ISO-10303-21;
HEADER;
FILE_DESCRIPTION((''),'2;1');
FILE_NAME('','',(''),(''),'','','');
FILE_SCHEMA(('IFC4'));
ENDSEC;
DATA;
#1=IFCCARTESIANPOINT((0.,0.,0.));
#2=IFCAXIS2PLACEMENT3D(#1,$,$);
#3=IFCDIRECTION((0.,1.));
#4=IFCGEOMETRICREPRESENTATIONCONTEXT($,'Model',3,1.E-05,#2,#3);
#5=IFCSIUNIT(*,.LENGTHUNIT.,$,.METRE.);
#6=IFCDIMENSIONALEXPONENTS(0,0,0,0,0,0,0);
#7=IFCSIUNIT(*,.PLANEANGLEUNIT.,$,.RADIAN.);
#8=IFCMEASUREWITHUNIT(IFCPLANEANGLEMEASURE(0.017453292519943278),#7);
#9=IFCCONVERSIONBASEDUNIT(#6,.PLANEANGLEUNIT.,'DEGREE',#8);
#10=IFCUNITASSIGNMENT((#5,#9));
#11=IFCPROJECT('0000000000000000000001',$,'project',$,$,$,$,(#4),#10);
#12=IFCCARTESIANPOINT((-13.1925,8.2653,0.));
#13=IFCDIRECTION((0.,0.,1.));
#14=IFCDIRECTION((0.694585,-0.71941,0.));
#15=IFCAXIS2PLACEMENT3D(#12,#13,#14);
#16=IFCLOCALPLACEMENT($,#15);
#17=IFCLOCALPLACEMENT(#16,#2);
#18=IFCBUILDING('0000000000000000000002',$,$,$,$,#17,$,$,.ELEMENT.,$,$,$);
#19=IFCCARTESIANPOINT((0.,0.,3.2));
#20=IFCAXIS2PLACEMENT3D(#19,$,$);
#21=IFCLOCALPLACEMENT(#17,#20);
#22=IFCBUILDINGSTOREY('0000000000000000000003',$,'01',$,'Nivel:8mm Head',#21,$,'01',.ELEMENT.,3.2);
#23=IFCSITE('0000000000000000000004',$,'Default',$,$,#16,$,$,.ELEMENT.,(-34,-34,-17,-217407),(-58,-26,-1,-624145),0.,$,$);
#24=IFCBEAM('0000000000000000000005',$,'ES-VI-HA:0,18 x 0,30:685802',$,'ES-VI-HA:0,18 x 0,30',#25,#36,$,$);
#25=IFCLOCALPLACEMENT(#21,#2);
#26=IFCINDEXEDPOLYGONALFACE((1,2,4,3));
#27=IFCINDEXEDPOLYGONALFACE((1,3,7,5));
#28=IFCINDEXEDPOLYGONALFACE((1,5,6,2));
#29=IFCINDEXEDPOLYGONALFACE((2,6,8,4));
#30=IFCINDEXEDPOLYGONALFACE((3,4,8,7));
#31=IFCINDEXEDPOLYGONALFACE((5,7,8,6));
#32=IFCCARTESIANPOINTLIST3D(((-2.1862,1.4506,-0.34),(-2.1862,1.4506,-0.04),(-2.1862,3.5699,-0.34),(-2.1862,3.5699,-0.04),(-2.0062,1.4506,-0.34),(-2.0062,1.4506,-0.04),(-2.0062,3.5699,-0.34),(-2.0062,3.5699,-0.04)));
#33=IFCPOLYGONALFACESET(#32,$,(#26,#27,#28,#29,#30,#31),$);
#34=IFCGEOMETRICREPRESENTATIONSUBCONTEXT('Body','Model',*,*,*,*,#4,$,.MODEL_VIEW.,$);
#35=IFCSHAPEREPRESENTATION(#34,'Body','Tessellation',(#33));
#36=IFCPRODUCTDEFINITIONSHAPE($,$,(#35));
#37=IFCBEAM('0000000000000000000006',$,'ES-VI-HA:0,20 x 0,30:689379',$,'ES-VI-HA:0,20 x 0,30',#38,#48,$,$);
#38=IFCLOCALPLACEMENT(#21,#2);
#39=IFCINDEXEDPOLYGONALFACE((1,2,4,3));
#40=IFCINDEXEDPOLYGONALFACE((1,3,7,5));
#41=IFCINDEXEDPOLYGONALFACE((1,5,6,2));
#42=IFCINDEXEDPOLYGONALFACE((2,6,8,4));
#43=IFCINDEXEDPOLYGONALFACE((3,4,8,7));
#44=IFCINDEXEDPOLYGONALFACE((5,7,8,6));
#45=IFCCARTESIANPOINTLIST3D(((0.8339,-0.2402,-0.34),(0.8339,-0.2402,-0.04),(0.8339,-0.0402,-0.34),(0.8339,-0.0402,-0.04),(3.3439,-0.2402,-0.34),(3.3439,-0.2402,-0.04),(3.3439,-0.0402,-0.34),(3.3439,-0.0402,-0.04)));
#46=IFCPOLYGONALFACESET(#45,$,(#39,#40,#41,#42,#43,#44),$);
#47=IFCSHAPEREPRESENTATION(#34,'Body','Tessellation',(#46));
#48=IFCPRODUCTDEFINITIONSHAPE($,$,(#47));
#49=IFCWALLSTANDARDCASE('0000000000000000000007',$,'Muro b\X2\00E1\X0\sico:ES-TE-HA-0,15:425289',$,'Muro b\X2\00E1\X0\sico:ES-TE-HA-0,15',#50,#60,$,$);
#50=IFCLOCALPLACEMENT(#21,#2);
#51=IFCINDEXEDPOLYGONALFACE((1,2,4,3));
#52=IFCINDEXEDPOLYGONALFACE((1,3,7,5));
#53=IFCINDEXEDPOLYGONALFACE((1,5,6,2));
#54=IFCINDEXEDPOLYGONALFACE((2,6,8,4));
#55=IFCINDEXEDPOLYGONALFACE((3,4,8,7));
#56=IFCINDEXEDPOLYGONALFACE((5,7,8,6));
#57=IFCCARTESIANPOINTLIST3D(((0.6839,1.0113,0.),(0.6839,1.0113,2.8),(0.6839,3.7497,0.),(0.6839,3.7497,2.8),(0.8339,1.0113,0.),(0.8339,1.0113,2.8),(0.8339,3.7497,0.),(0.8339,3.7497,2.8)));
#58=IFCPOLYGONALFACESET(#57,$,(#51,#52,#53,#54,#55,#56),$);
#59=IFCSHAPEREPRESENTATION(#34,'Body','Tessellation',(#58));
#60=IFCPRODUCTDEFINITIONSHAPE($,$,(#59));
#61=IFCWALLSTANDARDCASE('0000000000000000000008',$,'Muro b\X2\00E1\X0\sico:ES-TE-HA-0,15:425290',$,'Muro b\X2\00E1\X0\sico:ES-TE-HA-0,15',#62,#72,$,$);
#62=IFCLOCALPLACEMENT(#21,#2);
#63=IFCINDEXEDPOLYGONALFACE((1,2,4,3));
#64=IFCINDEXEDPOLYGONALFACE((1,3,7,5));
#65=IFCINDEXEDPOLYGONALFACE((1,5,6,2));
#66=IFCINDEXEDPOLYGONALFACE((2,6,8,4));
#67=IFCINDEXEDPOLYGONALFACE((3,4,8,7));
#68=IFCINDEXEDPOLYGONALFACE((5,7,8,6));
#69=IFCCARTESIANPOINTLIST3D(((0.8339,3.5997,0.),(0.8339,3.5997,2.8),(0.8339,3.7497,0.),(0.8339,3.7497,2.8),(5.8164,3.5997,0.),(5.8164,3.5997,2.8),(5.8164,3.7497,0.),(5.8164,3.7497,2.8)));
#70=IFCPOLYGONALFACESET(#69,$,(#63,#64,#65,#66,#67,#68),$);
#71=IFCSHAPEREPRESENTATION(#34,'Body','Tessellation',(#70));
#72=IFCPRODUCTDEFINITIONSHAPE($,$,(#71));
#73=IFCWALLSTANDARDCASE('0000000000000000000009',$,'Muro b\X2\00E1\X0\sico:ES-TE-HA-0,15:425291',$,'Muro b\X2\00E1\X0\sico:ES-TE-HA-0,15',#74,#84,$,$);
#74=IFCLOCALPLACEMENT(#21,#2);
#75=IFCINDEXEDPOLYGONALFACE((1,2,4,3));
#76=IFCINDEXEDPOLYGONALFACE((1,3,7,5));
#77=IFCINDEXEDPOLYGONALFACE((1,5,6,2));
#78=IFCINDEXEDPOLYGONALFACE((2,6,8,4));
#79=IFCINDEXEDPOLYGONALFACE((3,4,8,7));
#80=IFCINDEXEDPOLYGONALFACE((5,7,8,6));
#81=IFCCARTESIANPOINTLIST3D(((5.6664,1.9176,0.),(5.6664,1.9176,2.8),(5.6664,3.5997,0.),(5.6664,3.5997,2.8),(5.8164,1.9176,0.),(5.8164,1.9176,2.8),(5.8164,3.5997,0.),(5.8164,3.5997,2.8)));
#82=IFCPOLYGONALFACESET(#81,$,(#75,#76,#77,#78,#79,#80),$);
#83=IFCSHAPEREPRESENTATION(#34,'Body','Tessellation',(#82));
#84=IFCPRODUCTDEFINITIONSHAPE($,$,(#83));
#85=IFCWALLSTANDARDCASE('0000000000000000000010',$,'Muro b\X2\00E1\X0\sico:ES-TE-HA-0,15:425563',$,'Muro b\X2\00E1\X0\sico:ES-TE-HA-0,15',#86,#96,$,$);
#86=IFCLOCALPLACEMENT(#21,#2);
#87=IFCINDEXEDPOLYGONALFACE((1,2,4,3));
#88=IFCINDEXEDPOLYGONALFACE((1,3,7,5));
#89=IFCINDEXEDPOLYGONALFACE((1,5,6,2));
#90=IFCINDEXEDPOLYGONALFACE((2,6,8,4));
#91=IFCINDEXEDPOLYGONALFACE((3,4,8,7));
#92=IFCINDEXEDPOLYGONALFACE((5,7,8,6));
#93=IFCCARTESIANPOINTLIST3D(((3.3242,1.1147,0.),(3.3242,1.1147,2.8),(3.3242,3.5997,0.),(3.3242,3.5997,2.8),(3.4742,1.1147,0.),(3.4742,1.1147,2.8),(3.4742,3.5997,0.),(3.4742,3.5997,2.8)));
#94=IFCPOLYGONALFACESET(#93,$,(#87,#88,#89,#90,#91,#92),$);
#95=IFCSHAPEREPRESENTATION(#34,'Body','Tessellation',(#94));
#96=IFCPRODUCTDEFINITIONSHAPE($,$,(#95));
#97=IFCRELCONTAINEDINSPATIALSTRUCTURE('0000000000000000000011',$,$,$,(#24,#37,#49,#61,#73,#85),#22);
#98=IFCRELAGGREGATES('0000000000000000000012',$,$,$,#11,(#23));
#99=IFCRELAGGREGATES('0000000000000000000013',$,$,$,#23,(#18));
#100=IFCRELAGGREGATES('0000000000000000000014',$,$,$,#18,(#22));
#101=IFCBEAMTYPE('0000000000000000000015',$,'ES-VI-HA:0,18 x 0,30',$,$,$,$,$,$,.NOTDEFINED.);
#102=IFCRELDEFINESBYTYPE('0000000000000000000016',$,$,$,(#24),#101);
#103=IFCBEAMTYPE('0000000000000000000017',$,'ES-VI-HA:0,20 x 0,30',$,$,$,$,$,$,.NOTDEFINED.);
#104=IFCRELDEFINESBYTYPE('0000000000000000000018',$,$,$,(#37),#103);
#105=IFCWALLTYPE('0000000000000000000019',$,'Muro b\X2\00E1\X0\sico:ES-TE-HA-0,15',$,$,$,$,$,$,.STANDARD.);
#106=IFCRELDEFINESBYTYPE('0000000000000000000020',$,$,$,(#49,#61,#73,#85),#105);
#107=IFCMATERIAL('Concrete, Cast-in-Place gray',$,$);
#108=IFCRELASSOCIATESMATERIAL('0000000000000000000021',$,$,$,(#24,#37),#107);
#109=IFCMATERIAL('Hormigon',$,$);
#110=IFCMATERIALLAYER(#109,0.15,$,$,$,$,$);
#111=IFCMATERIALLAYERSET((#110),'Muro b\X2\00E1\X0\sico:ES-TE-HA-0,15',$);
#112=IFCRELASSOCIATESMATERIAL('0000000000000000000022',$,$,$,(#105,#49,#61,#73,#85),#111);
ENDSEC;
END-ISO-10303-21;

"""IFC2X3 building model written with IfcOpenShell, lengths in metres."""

from ifc_helpers import new_model, entity, si_unit, converted_unit, direction, frame, frame_2d, origin, place, context, subcontext, project, spatial, rectangle, extrude, material, layer, layer_set, layer_usage, type_object, element, save


model = new_model("IFC2X3")

# Units and contexts
model_context = context("Model", 3, precision=1e-05, world=origin(), true_north=direction((0.0, 1.0)))
body_context = subcontext(model_context, "Body", "Model", "MODEL_VIEW")
ifc_project = project(units=[si_unit("LENGTHUNIT", "METRE"), converted_unit("PLANEANGLEUNIT", "DEGREE", entity("IfcPlaneAngleMeasure", 0.017453292519943278), si_unit("PLANEANGLEUNIT", "RADIAN"), dimensions=[0, 0, 0, 0, 0, 0, 0])], contexts=[model_context])

# Site, building, storey
site_placement = place(None, frame((-13.1925, 8.2653, 0.0), z_axis=(0.0, 0.0, 1.0), x_axis=(0.694585, -0.71941, 0.0)))
site = spatial("IfcSite", under=ifc_project, at=site_placement, Name="Default", CompositionType="ELEMENT", RefLatitude=(-34, -34, -17, -217407), RefLongitude=(-58, -26, -1, -624145), RefElevation=0.0)
building_placement = place(site_placement, origin())
building = spatial("IfcBuilding", under=site, at=building_placement, CompositionType="ELEMENT")
storey_placement = place(building_placement, frame((0.0, 0.0, 3.2)))
storey = spatial("IfcBuildingStorey", under=building, at=storey_placement, Name="01", ObjectType="Nivel:8mm Head", LongName="01", CompositionType="ELEMENT", Elevation=3.2)

# Beams
ifc_material_1 = material(Name="Concrete, Cast-in-Place gray")
beam_type_1 = type_object("IfcBeamType", Name="ES-VI-HA:0,18 x 0,30", PredefinedType="NOTDEFINED")
beam_1_placement = place(storey_placement, frame((-2.0962, 3.5699, -0.04), z_axis=(0.0, 0.0, 1.0), x_axis=(0.0, -1.0, 0.0)))
element("IfcBeam", 1, at=beam_1_placement, inside=storey, type_object=beam_type_1, material=ifc_material_1, Name="ES-VI-HA:0,18 x 0,30:685802", ObjectType="ES-VI-HA:0,18 x 0,30", context=body_context, shape_type="SweptSolid", body=[
    extrude(rectangle(XDim=0.3, YDim=0.18, at=frame_2d((0.0, 0.0), x_axis=(1.0, 0.0))), frame((0.0, 0.0, -0.15), z_axis=(1.0, 0.0, 0.0), x_axis=(0.0, 0.0, -1.0)), (0.0, 0.0, 1.0), 2.1193),
])
beam_type_2 = type_object("IfcBeamType", Name="ES-VI-HA:0,20 x 0,30", PredefinedType="NOTDEFINED")
beam_2_placement = place(storey_placement, frame((0.8339, -0.1402, -0.04)))
element("IfcBeam", 2, at=beam_2_placement, inside=storey, type_object=beam_type_2, material=ifc_material_1, Name="ES-VI-HA:0,20 x 0,30:689379", ObjectType="ES-VI-HA:0,20 x 0,30", context=body_context, shape_type="SweptSolid", body=[
    extrude(rectangle(XDim=0.3, YDim=0.2, at=frame_2d((0.0, 0.0), x_axis=(1.0, 0.0))), frame((0.0, 0.0, -0.15), z_axis=(1.0, 0.0, 0.0), x_axis=(0.0, 0.0, -1.0)), (0.0, 0.0, 1.0), 2.51),
])

# Shared definitions
ifc_material_2 = material(Name="Hormigon")

# Walls
ifc_layer_1 = layer(ifc_material_2, 0.15)
ifc_layer_set_1 = layer_set([ifc_layer_1], Name="Muro básico:ES-TE-HA-0,15")
ifc_layer_usage_1 = layer_usage(ifc_layer_set_1, "AXIS2", "NEGATIVE", 0.075)
wall_type = type_object("IfcWallType", Name="Muro básico:ES-TE-HA-0,15", PredefinedType="STANDARD", material=ifc_layer_set_1)
wall_1_placement = place(storey_placement, frame((0.7589, 1.0113, 0.0), z_axis=(0.0, 0.0, 1.0), x_axis=(0.0, 1.0, 0.0)))
element("IfcWallStandardCase", 3, at=wall_1_placement, inside=storey, type_object=wall_type, material=ifc_layer_usage_1, Name="Muro básico:ES-TE-HA-0,15:425289", ObjectType="Muro básico:ES-TE-HA-0,15", context=body_context, shape_type="SweptSolid", body=[
    extrude(rectangle(XDim=2.7384, YDim=0.15, at=frame_2d((1.3692, 0.0), x_axis=(-1.0, 0.0))), origin(), (0.0, 0.0, 1.0), 2.8),
])
ifc_layer_usage_2 = layer_usage(ifc_layer_set_1, "AXIS2", "NEGATIVE", 0.075)
wall_2_placement = place(storey_placement, frame((0.8339, 3.6747, 0.0)))
element("IfcWallStandardCase", 4, at=wall_2_placement, inside=storey, type_object=wall_type, material=ifc_layer_usage_2, Name="Muro básico:ES-TE-HA-0,15:425290", ObjectType="Muro básico:ES-TE-HA-0,15", context=body_context, shape_type="SweptSolid", body=[
    extrude(rectangle(XDim=4.9825, YDim=0.15, at=frame_2d((2.4912, 0.0), x_axis=(-1.0, 0.0))), origin(), (0.0, 0.0, 1.0), 2.8),
])
ifc_layer_usage_3 = layer_usage(ifc_layer_set_1, "AXIS2", "NEGATIVE", 0.075)
wall_3_placement = place(storey_placement, frame((5.7414, 1.9176, 0.0), z_axis=(0.0, 0.0, 1.0), x_axis=(0.0, 1.0, 0.0)))
element("IfcWallStandardCase", 5, at=wall_3_placement, inside=storey, type_object=wall_type, material=ifc_layer_usage_3, Name="Muro básico:ES-TE-HA-0,15:425291", ObjectType="Muro básico:ES-TE-HA-0,15", context=body_context, shape_type="SweptSolid", body=[
    extrude(rectangle(XDim=1.682, YDim=0.15, at=frame_2d((0.841, 0.0), x_axis=(-1.0, 0.0))), origin(), (0.0, 0.0, 1.0), 2.8),
])
ifc_layer_usage_4 = layer_usage(ifc_layer_set_1, "AXIS2", "NEGATIVE", 0.075)
wall_4_placement = place(storey_placement, frame((3.3992, 3.5997, 0.0), z_axis=(0.0, 0.0, 1.0), x_axis=(0.0, -1.0, 0.0)))
element("IfcWallStandardCase", 6, at=wall_4_placement, inside=storey, type_object=wall_type, material=ifc_layer_usage_4, Name="Muro básico:ES-TE-HA-0,15:425563", ObjectType="Muro básico:ES-TE-HA-0,15", context=body_context, shape_type="SweptSolid", body=[
    extrude(rectangle(XDim=2.485, YDim=0.15, at=frame_2d((1.2425, 0.0), x_axis=(-1.0, 0.0))), origin(), (0.0, 0.0, 1.0), 2.8),
])

save(model, "model.ifc")
